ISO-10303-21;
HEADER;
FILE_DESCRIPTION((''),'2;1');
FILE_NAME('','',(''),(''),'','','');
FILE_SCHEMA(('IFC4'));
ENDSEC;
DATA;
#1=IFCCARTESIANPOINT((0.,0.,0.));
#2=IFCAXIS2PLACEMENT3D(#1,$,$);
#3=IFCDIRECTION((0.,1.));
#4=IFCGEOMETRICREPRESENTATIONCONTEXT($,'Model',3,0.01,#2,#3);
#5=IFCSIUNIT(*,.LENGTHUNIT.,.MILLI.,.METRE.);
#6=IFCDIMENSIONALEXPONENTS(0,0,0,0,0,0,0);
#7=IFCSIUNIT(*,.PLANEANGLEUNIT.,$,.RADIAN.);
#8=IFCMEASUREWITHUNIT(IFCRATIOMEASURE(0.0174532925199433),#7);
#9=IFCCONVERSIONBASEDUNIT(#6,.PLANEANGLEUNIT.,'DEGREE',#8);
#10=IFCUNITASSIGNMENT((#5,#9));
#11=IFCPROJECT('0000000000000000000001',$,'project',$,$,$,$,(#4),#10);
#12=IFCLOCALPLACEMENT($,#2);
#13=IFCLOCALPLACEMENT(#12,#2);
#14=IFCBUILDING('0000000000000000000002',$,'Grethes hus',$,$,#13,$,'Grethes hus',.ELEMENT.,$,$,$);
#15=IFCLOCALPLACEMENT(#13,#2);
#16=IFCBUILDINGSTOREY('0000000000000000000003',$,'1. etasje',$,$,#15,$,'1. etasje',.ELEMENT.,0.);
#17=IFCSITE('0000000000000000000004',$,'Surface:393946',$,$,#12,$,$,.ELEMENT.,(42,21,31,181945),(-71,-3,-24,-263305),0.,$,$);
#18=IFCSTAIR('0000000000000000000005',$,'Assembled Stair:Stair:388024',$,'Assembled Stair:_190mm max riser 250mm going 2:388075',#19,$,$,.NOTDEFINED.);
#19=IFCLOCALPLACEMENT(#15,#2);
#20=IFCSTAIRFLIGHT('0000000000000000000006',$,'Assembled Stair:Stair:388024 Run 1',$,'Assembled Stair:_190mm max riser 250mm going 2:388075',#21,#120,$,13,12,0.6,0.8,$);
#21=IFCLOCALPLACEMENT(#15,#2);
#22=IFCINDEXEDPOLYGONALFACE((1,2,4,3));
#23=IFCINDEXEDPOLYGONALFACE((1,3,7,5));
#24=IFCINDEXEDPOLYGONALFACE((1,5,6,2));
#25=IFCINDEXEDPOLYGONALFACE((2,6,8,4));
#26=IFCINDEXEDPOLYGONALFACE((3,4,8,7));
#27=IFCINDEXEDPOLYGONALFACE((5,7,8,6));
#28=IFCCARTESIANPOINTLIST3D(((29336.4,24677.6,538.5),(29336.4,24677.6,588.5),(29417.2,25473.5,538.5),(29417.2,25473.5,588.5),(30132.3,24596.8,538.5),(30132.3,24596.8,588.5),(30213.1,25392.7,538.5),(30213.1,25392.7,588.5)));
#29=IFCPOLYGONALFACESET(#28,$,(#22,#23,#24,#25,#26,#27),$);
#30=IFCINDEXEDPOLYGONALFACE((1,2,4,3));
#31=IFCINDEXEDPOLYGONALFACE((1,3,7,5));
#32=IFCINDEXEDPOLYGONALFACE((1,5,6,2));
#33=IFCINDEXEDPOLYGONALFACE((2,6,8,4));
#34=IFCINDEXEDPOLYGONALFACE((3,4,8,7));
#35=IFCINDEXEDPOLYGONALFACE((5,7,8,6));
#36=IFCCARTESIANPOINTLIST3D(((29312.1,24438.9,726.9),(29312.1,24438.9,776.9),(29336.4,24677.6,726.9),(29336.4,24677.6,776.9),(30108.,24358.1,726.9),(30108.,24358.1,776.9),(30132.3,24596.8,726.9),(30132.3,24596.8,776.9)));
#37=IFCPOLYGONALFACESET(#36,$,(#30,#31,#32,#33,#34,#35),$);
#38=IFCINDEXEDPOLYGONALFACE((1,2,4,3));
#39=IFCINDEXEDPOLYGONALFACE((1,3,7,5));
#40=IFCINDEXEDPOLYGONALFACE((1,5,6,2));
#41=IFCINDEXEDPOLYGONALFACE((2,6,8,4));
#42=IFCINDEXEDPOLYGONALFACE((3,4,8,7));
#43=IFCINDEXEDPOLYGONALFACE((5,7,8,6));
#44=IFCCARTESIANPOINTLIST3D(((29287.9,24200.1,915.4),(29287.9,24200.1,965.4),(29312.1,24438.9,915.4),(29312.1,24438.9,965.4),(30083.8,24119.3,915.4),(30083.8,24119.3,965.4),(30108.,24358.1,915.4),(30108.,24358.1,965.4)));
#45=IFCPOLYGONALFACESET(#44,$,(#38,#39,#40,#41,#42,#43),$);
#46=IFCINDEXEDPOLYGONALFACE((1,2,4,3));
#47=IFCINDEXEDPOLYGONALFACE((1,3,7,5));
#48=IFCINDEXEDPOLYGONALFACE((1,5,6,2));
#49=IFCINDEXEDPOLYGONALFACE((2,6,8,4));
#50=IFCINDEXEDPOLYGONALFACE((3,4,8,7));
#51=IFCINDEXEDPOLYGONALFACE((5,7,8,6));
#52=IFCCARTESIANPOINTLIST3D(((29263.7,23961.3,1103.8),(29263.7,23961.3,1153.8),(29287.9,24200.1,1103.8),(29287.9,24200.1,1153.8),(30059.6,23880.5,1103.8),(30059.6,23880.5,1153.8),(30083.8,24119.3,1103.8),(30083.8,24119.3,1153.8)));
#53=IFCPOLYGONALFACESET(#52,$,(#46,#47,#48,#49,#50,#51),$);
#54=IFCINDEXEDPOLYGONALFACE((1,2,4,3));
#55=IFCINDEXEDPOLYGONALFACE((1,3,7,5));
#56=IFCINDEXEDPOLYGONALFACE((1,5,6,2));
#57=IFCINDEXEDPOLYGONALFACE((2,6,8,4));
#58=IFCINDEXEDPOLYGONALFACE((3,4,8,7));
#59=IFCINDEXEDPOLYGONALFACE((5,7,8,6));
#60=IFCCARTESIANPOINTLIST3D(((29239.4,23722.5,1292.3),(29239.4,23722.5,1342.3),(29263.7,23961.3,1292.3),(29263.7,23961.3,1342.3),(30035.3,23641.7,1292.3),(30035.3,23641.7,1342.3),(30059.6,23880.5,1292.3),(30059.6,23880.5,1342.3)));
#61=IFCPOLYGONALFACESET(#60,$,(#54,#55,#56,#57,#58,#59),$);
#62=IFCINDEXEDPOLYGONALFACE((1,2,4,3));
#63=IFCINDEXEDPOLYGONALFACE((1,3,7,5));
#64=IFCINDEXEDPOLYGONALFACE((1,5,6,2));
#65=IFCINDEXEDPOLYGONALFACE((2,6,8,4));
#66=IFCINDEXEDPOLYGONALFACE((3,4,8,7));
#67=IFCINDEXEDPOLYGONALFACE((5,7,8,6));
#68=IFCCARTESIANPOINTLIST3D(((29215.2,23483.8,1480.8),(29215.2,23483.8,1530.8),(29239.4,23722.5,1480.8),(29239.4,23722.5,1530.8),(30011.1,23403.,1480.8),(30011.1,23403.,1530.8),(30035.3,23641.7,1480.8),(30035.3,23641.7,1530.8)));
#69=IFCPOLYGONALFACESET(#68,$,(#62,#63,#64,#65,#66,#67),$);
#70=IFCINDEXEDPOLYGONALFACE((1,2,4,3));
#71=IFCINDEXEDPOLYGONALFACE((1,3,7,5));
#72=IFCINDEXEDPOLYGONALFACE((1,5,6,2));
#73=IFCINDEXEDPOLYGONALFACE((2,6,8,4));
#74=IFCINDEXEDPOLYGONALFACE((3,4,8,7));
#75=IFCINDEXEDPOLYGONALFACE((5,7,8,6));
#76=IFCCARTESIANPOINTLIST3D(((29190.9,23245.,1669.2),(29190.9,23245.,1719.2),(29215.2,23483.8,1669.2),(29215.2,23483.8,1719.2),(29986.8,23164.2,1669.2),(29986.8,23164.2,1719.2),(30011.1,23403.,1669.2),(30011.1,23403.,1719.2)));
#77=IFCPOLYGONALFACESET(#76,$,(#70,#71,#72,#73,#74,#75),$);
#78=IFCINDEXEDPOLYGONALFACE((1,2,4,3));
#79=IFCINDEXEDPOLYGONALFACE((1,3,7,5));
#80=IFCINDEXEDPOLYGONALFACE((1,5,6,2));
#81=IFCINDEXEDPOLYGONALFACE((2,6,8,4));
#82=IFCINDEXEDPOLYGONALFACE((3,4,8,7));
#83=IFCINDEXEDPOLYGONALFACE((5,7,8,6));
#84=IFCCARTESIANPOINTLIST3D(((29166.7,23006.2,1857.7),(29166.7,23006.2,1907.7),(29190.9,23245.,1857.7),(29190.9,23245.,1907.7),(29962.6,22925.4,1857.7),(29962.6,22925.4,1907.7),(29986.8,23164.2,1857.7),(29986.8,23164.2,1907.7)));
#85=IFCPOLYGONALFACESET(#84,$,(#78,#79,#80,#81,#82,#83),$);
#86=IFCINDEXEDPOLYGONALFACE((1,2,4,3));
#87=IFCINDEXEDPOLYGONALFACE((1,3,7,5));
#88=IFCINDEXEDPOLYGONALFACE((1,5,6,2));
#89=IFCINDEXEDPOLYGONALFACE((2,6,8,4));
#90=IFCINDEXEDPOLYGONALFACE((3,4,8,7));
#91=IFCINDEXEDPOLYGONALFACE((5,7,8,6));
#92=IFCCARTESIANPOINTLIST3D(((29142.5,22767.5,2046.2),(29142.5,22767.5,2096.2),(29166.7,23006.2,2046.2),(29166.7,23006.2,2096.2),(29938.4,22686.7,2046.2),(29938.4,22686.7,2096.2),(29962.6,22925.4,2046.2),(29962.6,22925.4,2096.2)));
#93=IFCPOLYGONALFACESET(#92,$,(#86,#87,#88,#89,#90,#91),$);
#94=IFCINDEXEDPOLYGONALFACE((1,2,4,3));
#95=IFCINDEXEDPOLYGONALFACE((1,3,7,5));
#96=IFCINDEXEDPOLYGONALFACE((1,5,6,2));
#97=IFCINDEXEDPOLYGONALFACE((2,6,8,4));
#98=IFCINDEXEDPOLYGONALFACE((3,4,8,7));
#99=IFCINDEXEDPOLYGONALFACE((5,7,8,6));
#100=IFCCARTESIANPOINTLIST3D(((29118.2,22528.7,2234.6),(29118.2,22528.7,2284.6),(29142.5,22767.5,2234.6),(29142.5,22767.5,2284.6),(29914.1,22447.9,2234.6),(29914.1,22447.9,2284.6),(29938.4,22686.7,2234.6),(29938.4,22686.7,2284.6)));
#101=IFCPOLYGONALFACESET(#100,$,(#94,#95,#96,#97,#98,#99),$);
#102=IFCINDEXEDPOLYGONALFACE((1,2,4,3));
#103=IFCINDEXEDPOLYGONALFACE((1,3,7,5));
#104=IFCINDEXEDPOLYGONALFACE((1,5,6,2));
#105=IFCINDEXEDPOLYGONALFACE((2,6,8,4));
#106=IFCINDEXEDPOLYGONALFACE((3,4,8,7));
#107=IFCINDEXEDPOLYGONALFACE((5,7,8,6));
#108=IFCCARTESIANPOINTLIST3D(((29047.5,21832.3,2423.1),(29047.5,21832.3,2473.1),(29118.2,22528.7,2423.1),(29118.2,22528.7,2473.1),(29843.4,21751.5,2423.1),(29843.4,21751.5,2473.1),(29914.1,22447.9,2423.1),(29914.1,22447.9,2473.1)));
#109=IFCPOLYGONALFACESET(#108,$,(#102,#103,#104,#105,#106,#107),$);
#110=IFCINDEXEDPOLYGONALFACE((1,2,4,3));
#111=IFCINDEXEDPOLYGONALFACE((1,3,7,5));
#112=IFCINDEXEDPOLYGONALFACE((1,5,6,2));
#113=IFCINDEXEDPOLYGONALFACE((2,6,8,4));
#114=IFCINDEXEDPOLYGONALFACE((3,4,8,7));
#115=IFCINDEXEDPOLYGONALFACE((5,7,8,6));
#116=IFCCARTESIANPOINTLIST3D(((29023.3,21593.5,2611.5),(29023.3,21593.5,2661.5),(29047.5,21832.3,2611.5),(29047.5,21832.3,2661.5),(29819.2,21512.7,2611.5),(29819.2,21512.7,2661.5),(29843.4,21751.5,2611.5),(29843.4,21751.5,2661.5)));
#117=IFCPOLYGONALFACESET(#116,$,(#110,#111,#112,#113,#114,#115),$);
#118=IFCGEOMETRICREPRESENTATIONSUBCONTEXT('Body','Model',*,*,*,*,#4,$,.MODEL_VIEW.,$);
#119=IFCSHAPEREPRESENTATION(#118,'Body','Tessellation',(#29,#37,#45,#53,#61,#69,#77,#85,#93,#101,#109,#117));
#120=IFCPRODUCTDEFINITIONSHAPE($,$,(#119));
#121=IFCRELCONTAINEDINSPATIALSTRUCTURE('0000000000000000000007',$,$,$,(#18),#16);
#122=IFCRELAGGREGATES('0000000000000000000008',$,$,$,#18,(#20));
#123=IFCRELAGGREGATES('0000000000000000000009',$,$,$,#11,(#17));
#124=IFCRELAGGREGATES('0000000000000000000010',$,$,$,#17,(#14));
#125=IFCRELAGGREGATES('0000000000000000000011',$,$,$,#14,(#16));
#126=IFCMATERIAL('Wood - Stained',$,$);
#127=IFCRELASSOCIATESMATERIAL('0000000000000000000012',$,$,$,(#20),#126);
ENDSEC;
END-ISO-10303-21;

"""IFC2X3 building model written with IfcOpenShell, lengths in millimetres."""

from ifc_helpers import new_model, entity, si_unit, converted_unit, direction, frame, frame_2d, origin, place, context, subcontext, project, spatial, rectangle, extrude, material, element, aggregate, save


model = new_model("IFC2X3")

# Units and contexts
model_context = context("Model", 3, precision=0.01, world=origin(), true_north=direction((0.0, 1.0)))
body_context = subcontext(model_context, "Body", "Model", "MODEL_VIEW")
ifc_project = project(units=[si_unit("LENGTHUNIT", "METRE", prefix="MILLI"), converted_unit("PLANEANGLEUNIT", "DEGREE", entity("IfcRatioMeasure", 0.0174532925199433), si_unit("PLANEANGLEUNIT", "RADIAN"), dimensions=[0, 0, 0, 0, 0, 0, 0])], contexts=[model_context])

# Site, building, storey
site_placement = place(None, origin())
site = spatial("IfcSite", under=ifc_project, at=site_placement, Name="Surface:393946", CompositionType="ELEMENT", RefLatitude=(42, 21, 31, 181945), RefLongitude=(-71, -3, -24, -263305), RefElevation=0.0)
building_placement = place(site_placement, origin())
building = spatial("IfcBuilding", under=site, at=building_placement, Name="Grethes hus", LongName="Grethes hus", CompositionType="ELEMENT")
storey_placement = place(building_placement, origin())
storey = spatial("IfcBuildingStorey", under=building, at=storey_placement, Name="1. etasje", LongName="1. etasje", CompositionType="ELEMENT", Elevation=0.0)

# Stair, stair flight
stair_1_placement = place(storey_placement, origin())
stair_1 = element("IfcStair", 1, at=stair_1_placement, inside=storey, Name="Assembled Stair:Stair:388024", ObjectType="Assembled Stair:_190mm max riser 250mm going 2:388075", ShapeType="NOTDEFINED")
ifc_material_1 = material(Name="Wood - Stained")
stair_flight_1_placement = place(stair_1_placement, origin())
stair_flight_1 = element("IfcStairFlight", 2, at=stair_flight_1_placement, material=ifc_material_1, Name="Assembled Stair:Stair:388024 Run 1", ObjectType="Assembled Stair:_190mm max riser 250mm going 2:388075", NumberOfRiser=13, NumberOfTreads=12, RiserHeight=0.6, TreadLength=0.8, context=body_context, shape_type="SweptSolid", body=[
    extrude(rectangle(XDim=800.0, YDim=800.0, at=frame_2d((0.0, 0.0), x_axis=(1.0, 0.0))), frame((29774.7, 25035.2, 538.5), z_axis=(0.0, 0.0, 1.0), x_axis=(0.100996, 0.994887, 0.0)), (0.0, 0.0, 1.0), 50.0),
    extrude(rectangle(XDim=240.0, YDim=800.0, at=frame_2d((0.0, 0.0), x_axis=(1.0, 0.0))), frame((29722.2, 24517.9, 726.9), z_axis=(0.0, 0.0, 1.0), x_axis=(0.100996, 0.994887, 0.0)), (0.0, 0.0, 1.0), 50.0),
    extrude(rectangle(XDim=240.0, YDim=800.0, at=frame_2d((0.0, 0.0), x_axis=(1.0, 0.0))), frame((29698.0, 24279.1, 915.4), z_axis=(0.0, 0.0, 1.0), x_axis=(0.100996, 0.994887, 0.0)), (0.0, 0.0, 1.0), 50.0),
    extrude(rectangle(XDim=240.0, YDim=800.0, at=frame_2d((0.0, 0.0), x_axis=(1.0, 0.0))), frame((29673.7, 24040.3, 1103.8), z_axis=(0.0, 0.0, 1.0), x_axis=(0.100996, 0.994887, 0.0)), (0.0, 0.0, 1.0), 50.0),
    extrude(rectangle(XDim=240.0, YDim=800.0, at=frame_2d((0.0, 0.0), x_axis=(1.0, 0.0))), frame((29649.5, 23801.5, 1292.3), z_axis=(0.0, 0.0, 1.0), x_axis=(0.100996, 0.994887, 0.0)), (0.0, 0.0, 1.0), 50.0),
    extrude(rectangle(XDim=240.0, YDim=800.0, at=frame_2d((0.0, 0.0), x_axis=(1.0, 0.0))), frame((29625.2, 23562.8, 1480.8), z_axis=(0.0, 0.0, 1.0), x_axis=(0.100996, 0.994887, 0.0)), (0.0, 0.0, 1.0), 50.0),
    extrude(rectangle(XDim=240.0, YDim=800.0, at=frame_2d((0.0, 0.0), x_axis=(1.0, 0.0))), frame((29601.0, 23324.0, 1669.2), z_axis=(0.0, 0.0, 1.0), x_axis=(0.100996, 0.994887, 0.0)), (0.0, 0.0, 1.0), 50.0),
    extrude(rectangle(XDim=240.0, YDim=800.0, at=frame_2d((0.0, 0.0), x_axis=(1.0, 0.0))), frame((29576.8, 23085.2, 1857.7), z_axis=(0.0, 0.0, 1.0), x_axis=(0.100996, 0.994887, 0.0)), (0.0, 0.0, 1.0), 50.0),
    extrude(rectangle(XDim=240.0, YDim=800.0, at=frame_2d((0.0, 0.0), x_axis=(1.0, 0.0))), frame((29552.5, 22846.4, 2046.2), z_axis=(0.0, 0.0, 1.0), x_axis=(0.100996, 0.994887, 0.0)), (0.0, 0.0, 1.0), 50.0),
    extrude(rectangle(XDim=240.0, YDim=800.0, at=frame_2d((0.0, 0.0), x_axis=(1.0, 0.0))), frame((29528.3, 22607.7, 2234.6), z_axis=(0.0, 0.0, 1.0), x_axis=(0.100996, 0.994887, 0.0)), (0.0, 0.0, 1.0), 50.0),
    extrude(rectangle(XDim=700.0, YDim=800.0, at=frame_2d((0.0, 0.0), x_axis=(1.0, 0.0))), frame((29480.8, 22140.1, 2423.1), z_axis=(0.0, 0.0, 1.0), x_axis=(0.100996, 0.994887, 0.0)), (0.0, 0.0, 1.0), 50.0),
    extrude(rectangle(XDim=240.0, YDim=800.0, at=frame_2d((0.0, 0.0), x_axis=(1.0, 0.0))), frame((29433.4, 21672.5, 2611.5), z_axis=(0.0, 0.0, 1.0), x_axis=(0.100996, 0.994887, 0.0)), (0.0, 0.0, 1.0), 50.0),
])
aggregate(stair_1, [stair_flight_1])

save(model, "model.ifc")
